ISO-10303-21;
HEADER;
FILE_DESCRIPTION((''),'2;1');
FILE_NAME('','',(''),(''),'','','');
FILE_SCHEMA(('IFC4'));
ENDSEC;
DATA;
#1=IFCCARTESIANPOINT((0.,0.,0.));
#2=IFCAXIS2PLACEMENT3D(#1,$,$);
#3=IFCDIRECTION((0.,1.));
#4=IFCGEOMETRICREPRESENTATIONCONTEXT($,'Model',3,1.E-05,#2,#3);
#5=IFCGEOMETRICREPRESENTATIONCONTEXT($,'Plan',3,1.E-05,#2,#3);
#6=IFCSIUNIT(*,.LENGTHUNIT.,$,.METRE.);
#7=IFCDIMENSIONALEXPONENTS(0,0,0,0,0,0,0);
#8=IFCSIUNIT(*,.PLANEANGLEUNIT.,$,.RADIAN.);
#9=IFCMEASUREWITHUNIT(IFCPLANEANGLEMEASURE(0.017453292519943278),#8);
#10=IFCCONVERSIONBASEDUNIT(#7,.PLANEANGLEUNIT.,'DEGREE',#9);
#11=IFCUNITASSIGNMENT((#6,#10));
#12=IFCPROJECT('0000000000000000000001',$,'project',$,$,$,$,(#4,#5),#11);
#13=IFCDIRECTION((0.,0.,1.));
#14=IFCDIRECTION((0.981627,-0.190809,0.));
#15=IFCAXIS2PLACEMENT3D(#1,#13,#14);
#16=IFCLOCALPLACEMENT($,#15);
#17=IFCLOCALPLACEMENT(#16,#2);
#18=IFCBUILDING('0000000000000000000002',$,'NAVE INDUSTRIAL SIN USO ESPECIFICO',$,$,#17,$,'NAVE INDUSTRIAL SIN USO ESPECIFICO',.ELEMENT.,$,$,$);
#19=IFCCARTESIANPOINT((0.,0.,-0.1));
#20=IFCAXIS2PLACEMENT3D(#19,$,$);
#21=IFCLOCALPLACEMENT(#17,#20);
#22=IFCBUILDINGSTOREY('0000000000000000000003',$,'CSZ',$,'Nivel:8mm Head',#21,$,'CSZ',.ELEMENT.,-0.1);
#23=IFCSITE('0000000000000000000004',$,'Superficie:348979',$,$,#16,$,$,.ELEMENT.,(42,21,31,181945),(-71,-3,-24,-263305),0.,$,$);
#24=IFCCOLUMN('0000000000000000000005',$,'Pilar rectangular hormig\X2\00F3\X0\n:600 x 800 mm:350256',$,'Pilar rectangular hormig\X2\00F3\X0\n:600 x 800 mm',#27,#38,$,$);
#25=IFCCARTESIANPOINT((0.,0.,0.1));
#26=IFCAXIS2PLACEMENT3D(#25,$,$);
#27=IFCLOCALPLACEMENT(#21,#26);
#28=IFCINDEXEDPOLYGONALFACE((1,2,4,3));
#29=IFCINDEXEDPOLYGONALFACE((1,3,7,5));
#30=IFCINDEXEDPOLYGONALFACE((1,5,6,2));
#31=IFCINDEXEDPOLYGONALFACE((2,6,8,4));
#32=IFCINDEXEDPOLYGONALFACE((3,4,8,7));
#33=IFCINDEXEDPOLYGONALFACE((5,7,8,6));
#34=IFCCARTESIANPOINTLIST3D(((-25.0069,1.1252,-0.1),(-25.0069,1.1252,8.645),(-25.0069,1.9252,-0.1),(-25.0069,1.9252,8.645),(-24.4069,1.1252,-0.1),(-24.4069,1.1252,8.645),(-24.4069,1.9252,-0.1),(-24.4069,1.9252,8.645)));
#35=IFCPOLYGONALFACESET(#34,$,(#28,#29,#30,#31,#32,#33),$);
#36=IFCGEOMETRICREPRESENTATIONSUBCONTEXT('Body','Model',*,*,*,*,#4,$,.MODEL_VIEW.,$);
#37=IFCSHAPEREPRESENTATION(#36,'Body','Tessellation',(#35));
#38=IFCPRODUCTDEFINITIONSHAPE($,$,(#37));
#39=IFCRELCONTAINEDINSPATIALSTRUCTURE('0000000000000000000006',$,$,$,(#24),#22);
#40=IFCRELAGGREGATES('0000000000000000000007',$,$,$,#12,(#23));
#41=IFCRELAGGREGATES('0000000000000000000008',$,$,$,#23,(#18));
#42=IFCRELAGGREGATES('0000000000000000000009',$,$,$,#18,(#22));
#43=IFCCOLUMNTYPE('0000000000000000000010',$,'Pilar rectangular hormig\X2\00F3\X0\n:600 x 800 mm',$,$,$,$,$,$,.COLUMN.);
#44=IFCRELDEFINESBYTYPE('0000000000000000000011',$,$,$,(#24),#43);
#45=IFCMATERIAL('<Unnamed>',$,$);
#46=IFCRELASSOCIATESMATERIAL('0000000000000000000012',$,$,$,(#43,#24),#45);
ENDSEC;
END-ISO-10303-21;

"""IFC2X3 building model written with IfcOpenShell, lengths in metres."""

from ifc_helpers import new_model, entity, si_unit, converted_unit, direction, frame, frame_2d, origin, place, context, subcontext, project, spatial, rectangle, extrude, source, transform, mapped, material, type_object, type_shapes, element, save


model = new_model("IFC2X3")

# Units and contexts
model_context = context("Model", 3, precision=1e-05, world=origin(), true_north=direction((0.0, 1.0)))
plan_context = context("Plan", 3, precision=1e-05, world=origin(), true_north=direction((0.0, 1.0)))
body_context = subcontext(model_context, "Body", "Model", "MODEL_VIEW")
ifc_project = project(units=[si_unit("LENGTHUNIT", "METRE"), converted_unit("PLANEANGLEUNIT", "DEGREE", entity("IfcPlaneAngleMeasure", 0.017453292519943278), si_unit("PLANEANGLEUNIT", "RADIAN"), dimensions=[0, 0, 0, 0, 0, 0, 0])], contexts=[model_context, plan_context])

# Site, building, storey
site_placement = place(None, frame((0.0, 0.0, 0.0), z_axis=(0.0, 0.0, 1.0), x_axis=(0.981627, -0.190809, 0.0)))
site = spatial("IfcSite", under=ifc_project, at=site_placement, Name="Superficie:348979", CompositionType="ELEMENT", RefLatitude=(42, 21, 31, 181945), RefLongitude=(-71, -3, -24, -263305), RefElevation=0.0)
building_placement = place(site_placement, origin())
building = spatial("IfcBuilding", under=site, at=building_placement, Name="NAVE INDUSTRIAL SIN USO ESPECIFICO", LongName="NAVE INDUSTRIAL SIN USO ESPECIFICO", CompositionType="ELEMENT")
storey_placement = place(building_placement, frame((0.0, 0.0, -0.1)))
storey = spatial("IfcBuildingStorey", under=building, at=storey_placement, Name="CSZ", ObjectType="Nivel:8mm Head", LongName="CSZ", CompositionType="ELEMENT", Elevation=-0.1)

# Column
ifc_material_1 = material(Name="<Unnamed>")
column_type = type_object("IfcColumnType", Name="Pilar rectangular hormigón:600 x 800 mm", PredefinedType="COLUMN", material=ifc_material_1)
shared_shape = source(origin(), body_context, "Body", "SweptSolid", [
    extrude(rectangle(XDim=0.6, YDim=0.8, at=frame_2d((0.0, 0.0), x_axis=(1.0, 0.0))), frame((-24.7069, 1.5252, -0.1)), (0.0, 0.0, 1.0), 8.745),
])
type_shapes(column_type, [shared_shape])
column_placement = place(storey_placement, frame((0.0, 0.0, 0.1)))
element("IfcColumn", 1, at=column_placement, inside=storey, type_object=column_type, material=ifc_material_1, Name="Pilar rectangular hormigón:600 x 800 mm:350256", ObjectType="Pilar rectangular hormigón:600 x 800 mm", context=body_context, shape_type="MappedRepresentation", body=[
    mapped(shared_shape, transform((0.0, 0.0, 0.0), scale=1.0)),
])

save(model, "model.ifc")
